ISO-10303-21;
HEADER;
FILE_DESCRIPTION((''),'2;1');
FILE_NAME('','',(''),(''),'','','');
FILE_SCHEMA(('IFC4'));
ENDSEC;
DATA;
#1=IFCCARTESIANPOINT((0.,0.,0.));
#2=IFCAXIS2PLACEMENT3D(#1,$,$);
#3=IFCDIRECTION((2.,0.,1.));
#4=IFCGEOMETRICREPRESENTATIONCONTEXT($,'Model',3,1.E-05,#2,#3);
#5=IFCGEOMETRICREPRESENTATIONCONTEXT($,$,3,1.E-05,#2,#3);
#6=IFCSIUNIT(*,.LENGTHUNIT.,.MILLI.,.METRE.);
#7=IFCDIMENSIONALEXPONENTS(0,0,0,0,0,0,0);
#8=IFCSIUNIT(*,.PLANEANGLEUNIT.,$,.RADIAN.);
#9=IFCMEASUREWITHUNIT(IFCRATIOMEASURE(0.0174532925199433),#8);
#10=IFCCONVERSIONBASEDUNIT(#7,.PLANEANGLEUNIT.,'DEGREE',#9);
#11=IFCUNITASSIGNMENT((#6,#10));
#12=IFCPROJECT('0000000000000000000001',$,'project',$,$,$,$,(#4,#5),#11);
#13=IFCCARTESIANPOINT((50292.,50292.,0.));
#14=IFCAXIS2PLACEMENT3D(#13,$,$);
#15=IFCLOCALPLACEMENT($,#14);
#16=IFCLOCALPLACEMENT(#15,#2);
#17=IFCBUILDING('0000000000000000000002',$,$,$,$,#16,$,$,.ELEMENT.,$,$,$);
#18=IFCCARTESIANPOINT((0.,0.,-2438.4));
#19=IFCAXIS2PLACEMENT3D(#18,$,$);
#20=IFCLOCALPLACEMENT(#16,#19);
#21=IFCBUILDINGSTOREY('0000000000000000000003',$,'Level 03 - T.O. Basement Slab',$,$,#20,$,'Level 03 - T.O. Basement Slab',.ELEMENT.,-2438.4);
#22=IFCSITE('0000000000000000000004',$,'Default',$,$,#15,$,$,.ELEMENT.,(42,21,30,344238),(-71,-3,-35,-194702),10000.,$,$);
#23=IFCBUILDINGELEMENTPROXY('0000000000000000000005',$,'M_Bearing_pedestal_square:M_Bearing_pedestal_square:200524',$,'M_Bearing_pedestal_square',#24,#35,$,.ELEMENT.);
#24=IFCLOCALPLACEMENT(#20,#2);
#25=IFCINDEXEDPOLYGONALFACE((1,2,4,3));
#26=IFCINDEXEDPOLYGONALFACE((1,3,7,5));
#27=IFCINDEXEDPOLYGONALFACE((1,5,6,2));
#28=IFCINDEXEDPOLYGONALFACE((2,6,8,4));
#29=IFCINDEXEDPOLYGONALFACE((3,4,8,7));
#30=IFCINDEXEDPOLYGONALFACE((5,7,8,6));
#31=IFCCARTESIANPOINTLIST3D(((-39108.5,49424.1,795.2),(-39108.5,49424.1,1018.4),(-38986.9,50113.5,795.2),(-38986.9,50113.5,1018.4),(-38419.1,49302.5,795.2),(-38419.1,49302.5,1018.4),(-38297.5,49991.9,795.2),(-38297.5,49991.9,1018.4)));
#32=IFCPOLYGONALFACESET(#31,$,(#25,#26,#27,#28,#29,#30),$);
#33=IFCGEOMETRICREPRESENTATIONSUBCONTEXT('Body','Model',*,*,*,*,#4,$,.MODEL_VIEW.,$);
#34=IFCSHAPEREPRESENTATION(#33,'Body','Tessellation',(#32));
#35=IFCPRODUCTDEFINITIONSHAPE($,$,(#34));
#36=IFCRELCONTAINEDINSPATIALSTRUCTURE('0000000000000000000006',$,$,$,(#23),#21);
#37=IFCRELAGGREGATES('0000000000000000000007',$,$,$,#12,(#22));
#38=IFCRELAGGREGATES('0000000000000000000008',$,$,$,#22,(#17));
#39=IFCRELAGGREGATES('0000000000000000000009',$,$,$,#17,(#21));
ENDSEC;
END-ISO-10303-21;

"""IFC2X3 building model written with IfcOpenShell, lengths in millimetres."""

from ifc_helpers import new_model, entity, si_unit, converted_unit, direction, frame, origin, origin_2d_with_axis, place, context, subcontext, project, spatial, rectangle, extrude, source, transform, mapped, element, save


model = new_model("IFC2X3")

# Units and contexts
model_context = context("Model", 3, precision=1e-05, world=origin(), true_north=direction((2.0, 0.0, 1.0)))
context_of_model = context(None, 3, precision=1e-05, world=origin(), true_north=direction((2.0, 0.0, 1.0)))
body_context = subcontext(model_context, "Body", "Model", "MODEL_VIEW")
ifc_project = project(units=[si_unit("LENGTHUNIT", "METRE", prefix="MILLI"), converted_unit("PLANEANGLEUNIT", "DEGREE", entity("IfcRatioMeasure", 0.0174532925199433), si_unit("PLANEANGLEUNIT", "RADIAN"), dimensions=[0, 0, 0, 0, 0, 0, 0])], contexts=[model_context, context_of_model])

# Site, building, storey
site_placement = place(None, frame((50292.0, 50292.0, 0.0)))
site = spatial("IfcSite", under=ifc_project, at=site_placement, Name="Default", CompositionType="ELEMENT", RefLatitude=(42, 21, 30, 344238), RefLongitude=(-71, -3, -35, -194702), RefElevation=10000.0)
building_placement = place(site_placement, origin())
building = spatial("IfcBuilding", under=site, at=building_placement, CompositionType="ELEMENT")
storey_placement = place(building_placement, frame((0.0, 0.0, -2438.4)))
storey = spatial("IfcBuildingStorey", under=building, at=storey_placement, Name="Level 03 - T.O. Basement Slab", LongName="Level 03 - T.O. Basement Slab", CompositionType="ELEMENT", Elevation=-2438.4)

# Building element proxy
shared_shape_1 = source(origin(), body_context, "Body", "SweptSolid", [
    extrude(rectangle(XDim=700.0, YDim=700.0, at=origin_2d_with_axis()), frame((0.0, 0.0, -223.2)), (0.0, 0.0, 1.0), 223.2),
])
proxy_1_placement = place(storey_placement, frame((-38703.0, 49708.0, 1018.4), z_axis=(0.0, 0.0, 1.0), x_axis=(0.173648, 0.984808, 0.0)))
element("IfcBuildingElementProxy", 1, at=proxy_1_placement, inside=storey, Name="M_Bearing_pedestal_square:M_Bearing_pedestal_square:200524", ObjectType="M_Bearing_pedestal_square", CompositionType="ELEMENT", context=body_context, shape_type="MappedRepresentation", body=[
    mapped(shared_shape_1, transform((0.0, 0.0, 0.0), scale=1.0)),
])

save(model, "model.ifc")
